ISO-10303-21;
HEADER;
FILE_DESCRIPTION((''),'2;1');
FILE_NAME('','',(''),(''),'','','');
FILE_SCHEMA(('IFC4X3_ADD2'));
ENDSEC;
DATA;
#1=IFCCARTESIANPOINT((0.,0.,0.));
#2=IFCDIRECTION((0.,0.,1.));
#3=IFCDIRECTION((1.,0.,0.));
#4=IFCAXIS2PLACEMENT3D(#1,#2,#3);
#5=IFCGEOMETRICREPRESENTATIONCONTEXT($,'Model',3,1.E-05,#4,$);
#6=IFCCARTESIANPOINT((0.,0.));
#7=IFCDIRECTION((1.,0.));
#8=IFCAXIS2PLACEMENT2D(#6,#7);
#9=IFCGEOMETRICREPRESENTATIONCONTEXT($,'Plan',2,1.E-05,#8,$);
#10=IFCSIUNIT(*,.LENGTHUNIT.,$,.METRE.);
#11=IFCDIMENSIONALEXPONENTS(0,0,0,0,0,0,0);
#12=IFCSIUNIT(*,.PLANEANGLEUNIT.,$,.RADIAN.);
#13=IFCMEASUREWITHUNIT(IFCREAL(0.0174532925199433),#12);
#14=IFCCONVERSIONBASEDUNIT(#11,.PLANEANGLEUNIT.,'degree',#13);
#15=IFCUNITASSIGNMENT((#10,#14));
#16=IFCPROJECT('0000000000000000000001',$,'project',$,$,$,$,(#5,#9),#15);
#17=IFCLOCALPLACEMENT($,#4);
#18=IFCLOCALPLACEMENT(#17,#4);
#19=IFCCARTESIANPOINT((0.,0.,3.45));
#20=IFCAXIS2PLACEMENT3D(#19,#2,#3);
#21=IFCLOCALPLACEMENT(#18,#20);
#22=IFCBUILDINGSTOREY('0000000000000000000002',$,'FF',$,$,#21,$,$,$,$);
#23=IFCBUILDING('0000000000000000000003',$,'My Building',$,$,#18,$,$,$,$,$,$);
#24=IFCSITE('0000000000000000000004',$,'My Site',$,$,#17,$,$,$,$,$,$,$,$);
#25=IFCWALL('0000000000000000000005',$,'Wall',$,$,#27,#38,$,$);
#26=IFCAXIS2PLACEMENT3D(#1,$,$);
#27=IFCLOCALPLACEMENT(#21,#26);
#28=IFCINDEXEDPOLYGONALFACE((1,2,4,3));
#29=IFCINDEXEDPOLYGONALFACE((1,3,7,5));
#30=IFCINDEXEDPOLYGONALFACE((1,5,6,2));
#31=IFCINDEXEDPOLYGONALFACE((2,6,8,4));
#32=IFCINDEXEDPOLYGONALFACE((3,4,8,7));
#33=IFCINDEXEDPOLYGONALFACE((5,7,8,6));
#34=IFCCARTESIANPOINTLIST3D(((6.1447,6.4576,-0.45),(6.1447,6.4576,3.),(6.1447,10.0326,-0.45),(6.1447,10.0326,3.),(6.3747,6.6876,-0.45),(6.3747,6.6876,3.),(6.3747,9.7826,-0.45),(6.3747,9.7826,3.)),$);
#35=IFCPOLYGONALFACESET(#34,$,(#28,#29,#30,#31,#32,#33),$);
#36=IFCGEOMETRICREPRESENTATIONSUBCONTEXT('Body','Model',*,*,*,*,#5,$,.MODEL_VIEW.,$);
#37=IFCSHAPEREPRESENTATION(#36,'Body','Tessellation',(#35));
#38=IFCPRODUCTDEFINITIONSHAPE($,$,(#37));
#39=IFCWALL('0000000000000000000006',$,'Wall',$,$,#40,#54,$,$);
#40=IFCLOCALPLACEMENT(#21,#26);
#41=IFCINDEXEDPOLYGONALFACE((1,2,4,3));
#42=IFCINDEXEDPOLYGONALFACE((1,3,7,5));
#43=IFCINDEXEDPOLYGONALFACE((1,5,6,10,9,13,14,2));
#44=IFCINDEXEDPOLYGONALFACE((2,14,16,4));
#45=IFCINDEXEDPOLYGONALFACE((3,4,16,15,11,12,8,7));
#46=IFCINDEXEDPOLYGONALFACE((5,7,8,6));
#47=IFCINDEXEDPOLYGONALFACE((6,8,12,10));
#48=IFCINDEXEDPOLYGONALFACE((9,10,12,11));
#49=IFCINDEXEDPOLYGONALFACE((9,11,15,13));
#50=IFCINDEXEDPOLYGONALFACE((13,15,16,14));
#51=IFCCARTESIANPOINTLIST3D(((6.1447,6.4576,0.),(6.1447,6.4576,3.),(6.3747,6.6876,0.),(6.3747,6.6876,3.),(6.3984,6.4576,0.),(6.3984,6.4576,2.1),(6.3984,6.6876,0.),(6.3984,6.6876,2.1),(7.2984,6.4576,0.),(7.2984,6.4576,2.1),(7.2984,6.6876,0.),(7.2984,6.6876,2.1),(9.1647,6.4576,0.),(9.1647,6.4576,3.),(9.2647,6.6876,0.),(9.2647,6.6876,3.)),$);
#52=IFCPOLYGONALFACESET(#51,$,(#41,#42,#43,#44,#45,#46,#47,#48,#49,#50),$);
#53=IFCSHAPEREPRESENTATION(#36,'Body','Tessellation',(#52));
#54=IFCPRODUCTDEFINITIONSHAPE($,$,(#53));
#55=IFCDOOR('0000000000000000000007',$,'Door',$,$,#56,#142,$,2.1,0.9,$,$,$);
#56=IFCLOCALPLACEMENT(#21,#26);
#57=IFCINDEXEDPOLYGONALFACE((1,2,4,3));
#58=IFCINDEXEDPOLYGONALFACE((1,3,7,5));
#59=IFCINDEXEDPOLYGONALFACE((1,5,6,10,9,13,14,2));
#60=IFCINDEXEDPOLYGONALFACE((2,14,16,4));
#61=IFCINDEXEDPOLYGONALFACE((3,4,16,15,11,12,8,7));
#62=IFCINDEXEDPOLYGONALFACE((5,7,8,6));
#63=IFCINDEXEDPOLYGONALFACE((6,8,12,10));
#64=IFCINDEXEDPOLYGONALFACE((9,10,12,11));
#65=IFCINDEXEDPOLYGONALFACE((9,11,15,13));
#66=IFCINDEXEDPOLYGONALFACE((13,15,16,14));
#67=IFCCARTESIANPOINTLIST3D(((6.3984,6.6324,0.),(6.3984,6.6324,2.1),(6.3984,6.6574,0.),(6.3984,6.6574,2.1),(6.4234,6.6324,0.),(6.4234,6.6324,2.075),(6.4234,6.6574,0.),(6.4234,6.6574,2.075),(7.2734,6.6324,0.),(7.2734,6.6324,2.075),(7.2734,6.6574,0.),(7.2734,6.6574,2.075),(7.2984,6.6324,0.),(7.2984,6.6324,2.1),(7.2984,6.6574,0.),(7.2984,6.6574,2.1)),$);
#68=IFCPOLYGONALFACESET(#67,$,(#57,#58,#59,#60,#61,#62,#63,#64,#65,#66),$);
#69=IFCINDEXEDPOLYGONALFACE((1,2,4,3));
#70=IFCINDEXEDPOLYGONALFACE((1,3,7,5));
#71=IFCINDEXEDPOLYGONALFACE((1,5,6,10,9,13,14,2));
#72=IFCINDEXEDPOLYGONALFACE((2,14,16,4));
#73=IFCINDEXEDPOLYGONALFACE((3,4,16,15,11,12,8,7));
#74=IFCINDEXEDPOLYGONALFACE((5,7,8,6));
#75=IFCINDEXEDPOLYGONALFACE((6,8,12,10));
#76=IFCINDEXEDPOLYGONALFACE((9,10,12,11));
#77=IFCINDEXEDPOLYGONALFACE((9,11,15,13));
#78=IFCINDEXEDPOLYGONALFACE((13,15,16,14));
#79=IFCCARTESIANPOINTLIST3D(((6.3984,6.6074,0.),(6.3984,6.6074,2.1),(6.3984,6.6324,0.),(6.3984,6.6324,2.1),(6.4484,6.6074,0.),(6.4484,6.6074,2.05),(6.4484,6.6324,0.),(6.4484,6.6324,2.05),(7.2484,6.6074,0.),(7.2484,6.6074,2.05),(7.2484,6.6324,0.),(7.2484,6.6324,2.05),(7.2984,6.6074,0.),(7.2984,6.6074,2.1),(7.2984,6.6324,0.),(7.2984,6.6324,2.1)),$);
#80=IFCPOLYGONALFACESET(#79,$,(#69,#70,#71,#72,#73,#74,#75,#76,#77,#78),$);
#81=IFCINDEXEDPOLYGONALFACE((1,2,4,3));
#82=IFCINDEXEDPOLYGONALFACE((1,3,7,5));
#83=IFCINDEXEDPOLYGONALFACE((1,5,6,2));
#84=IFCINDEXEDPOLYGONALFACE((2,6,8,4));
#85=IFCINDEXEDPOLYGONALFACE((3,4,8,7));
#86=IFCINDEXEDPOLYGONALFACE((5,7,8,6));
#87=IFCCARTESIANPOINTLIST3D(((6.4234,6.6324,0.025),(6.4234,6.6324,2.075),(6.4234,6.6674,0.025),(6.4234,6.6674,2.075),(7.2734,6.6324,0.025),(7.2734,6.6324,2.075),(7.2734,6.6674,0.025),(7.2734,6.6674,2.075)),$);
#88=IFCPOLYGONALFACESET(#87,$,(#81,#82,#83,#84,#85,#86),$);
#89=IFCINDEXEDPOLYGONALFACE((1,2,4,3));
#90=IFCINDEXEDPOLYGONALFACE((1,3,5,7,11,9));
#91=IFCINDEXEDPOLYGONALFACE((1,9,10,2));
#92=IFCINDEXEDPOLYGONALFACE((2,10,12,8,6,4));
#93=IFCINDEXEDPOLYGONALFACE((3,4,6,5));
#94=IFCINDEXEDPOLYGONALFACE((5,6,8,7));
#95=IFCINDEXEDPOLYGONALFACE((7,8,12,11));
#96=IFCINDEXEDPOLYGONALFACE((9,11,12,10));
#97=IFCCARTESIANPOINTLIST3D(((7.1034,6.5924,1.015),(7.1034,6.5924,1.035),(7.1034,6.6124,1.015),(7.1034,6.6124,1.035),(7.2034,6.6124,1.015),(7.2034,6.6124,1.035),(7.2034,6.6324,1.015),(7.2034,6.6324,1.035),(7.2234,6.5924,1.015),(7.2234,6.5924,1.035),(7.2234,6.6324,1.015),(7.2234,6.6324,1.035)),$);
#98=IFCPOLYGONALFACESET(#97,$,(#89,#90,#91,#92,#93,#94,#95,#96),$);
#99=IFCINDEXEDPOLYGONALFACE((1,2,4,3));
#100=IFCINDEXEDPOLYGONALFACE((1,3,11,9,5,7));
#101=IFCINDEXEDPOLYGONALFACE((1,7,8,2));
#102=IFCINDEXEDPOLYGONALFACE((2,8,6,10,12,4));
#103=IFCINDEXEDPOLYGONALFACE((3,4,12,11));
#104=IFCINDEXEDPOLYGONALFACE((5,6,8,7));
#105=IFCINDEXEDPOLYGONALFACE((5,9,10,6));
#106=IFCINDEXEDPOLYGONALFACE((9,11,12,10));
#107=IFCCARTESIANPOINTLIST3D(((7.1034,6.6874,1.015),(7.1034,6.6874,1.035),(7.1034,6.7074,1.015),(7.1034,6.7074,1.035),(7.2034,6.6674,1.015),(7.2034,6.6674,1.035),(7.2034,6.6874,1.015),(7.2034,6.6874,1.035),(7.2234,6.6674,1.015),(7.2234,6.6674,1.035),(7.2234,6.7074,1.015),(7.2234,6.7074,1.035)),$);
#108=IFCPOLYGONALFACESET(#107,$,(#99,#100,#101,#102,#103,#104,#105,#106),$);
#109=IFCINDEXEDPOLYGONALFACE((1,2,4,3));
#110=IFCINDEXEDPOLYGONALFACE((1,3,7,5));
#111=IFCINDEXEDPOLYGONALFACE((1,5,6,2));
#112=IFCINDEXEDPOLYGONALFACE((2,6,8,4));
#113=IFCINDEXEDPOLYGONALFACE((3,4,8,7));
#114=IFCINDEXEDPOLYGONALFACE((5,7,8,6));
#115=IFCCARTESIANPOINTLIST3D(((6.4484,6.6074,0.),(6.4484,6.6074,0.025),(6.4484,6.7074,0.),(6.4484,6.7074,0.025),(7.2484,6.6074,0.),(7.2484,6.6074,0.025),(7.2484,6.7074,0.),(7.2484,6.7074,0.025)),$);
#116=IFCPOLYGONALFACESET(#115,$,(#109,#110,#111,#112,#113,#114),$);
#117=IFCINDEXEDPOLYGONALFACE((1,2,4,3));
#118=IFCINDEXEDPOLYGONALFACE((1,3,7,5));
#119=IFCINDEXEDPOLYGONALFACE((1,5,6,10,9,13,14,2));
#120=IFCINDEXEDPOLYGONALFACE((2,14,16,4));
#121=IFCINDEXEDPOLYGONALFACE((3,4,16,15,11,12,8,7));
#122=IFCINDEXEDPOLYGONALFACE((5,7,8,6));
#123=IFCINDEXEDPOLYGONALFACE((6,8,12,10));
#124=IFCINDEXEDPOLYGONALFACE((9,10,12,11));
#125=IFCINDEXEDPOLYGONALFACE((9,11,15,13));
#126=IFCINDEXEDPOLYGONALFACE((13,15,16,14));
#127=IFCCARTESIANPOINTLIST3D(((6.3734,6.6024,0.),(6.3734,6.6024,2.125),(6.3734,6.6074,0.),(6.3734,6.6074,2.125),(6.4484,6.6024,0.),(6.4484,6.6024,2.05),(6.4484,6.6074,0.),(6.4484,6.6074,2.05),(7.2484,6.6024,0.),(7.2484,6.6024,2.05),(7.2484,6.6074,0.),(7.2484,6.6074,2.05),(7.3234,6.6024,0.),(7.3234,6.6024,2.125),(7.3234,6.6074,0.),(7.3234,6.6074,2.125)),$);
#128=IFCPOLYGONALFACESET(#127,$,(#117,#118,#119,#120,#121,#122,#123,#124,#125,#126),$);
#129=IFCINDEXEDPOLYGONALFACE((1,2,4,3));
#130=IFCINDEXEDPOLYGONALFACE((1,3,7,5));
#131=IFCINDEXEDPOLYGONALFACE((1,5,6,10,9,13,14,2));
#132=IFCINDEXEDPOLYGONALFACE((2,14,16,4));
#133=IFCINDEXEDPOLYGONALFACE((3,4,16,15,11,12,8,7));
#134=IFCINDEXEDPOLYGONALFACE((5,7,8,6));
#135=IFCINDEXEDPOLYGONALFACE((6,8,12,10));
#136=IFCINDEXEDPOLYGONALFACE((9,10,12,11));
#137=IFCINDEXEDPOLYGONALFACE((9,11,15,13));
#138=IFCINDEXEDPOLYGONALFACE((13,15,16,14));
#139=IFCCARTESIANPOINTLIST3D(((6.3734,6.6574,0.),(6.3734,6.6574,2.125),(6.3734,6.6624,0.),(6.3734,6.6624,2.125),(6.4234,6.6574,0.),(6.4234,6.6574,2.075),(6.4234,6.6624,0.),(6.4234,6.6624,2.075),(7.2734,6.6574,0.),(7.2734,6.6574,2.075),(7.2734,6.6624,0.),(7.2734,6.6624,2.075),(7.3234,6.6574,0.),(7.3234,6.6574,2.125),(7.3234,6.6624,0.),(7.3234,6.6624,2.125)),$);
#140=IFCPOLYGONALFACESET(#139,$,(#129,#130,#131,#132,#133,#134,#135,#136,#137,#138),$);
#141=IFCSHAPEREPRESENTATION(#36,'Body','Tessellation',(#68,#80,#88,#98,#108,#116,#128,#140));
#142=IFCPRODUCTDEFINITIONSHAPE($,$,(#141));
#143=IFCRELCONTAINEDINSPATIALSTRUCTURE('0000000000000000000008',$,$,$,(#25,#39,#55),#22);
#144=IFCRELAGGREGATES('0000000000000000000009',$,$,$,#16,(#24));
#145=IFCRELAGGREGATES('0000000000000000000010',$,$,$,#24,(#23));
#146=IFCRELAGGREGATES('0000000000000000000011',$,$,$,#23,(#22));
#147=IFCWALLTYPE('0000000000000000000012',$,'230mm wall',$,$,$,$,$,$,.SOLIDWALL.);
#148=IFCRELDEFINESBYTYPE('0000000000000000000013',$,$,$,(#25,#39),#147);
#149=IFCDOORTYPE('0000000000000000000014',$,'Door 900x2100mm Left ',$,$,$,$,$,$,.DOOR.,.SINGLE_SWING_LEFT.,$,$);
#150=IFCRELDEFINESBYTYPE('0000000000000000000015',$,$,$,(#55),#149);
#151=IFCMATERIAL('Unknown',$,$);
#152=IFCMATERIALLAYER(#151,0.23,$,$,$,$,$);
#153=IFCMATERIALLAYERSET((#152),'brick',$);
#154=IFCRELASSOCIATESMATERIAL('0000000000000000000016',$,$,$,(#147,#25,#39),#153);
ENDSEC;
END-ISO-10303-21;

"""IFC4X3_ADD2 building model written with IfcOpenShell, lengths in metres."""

from ifc_helpers import new_model, entity, si_unit, converted_unit, frame, origin_with_axes, origin_2d_with_axis, place, context, subcontext, project, spatial, line, indexed_curve, outline, extrude, shape, source, transform, mapped, material, layer, layer_set, layer_usage, type_object, type_shapes, element, fill, save


model = new_model("IFC4X3_ADD2")

# Units and contexts
model_context = context("Model", 3, precision=1e-05, world=origin_with_axes())
plan_context = context("Plan", 2, precision=1e-05, world=origin_2d_with_axis())
body_context_1 = subcontext(model_context, "Body", "Model", "MODEL_VIEW")
body_context_2 = subcontext(plan_context, "Body", "Plan", "PLAN_VIEW")
ifc_project = project(units=[si_unit("LENGTHUNIT", "METRE"), converted_unit("PLANEANGLEUNIT", "degree", entity("IfcReal", 0.0174532925199433), si_unit("PLANEANGLEUNIT", "RADIAN"), dimensions=[0, 0, 0, 0, 0, 0, 0])], contexts=[model_context, plan_context])

# Site, building, storey
site_placement = place(None, origin_with_axes())
site = spatial("IfcSite", under=ifc_project, at=site_placement, Name="My Site")
building_placement = place(site_placement, origin_with_axes())
building = spatial("IfcBuilding", under=site, at=building_placement, Name="My Building")
storey_placement = place(building_placement, frame((0.0, 0.0, 3.45), z_axis=(0.0, 0.0, 1.0), x_axis=(1.0, 0.0, 0.0)))
storey = spatial("IfcBuildingStorey", under=building, at=storey_placement, Name="FF")

# Shared definitions
ifc_material = material(Name="Unknown")

# Shared definitions
ifc_layer_1 = layer(ifc_material, 0.23)
ifc_layer_set_1 = layer_set([ifc_layer_1], Name="brick")
wall_type_1 = type_object("IfcWallType", Name="230mm wall", PredefinedType="SOLIDWALL", material=ifc_layer_set_1)

# Wall
ifc_layer_usage_1 = layer_usage(ifc_layer_set_1, "AXIS2", "POSITIVE", 0.0)
wall_1_placement = place(storey_placement, frame((6.3747, 6.6876, -0.45), z_axis=(0.0, 0.0, 1.0), x_axis=(0.0, 1.0, 0.0)))
element("IfcWall", 1, at=wall_1_placement, inside=storey, type_object=wall_type_1, material=ifc_layer_usage_1, Name="Wall", context=body_context_1, shape_type="SweptSolid", body=[
    extrude(outline(indexed_curve([(0.0, 0.0), (-0.23, 0.23), (3.345, 0.23), (3.095, 0.0)], segments=[line(1, 2, 3, 4, 1)])), origin_with_axes(), (0.0, 0.0, 1.0), 3.45),
])

# Wall, opening, door
ifc_layer_usage_2 = layer_usage(ifc_layer_set_1, "AXIS2", "POSITIVE", 0.0)
wall_2_placement = place(storey_placement, frame((9.2647, 6.6876, 0.0), z_axis=(0.0, 0.0, 1.0), x_axis=(-1.0, 0.0, 0.0)))
wall_2 = element("IfcWall", 2, at=wall_2_placement, inside=storey, type_object=wall_type_1, material=ifc_layer_usage_2, Name="Wall", context=body_context_1, shape_type="SweptSolid", body=[
    extrude(outline(indexed_curve([(0.0, 0.0), (0.1, 0.23), (3.12, 0.23), (2.89, 0.0)], segments=[line(1, 2, 3, 4, 1)])), origin_with_axes(), (0.0, 0.0, 1.0), 3.0),
])
shared_shape_1 = source(origin_with_axes(), body_context_1, "Body", "SweptSolid", [
    extrude(outline(indexed_curve([(0.0, 0.0), (0.9, 0.0), (0.9, 2.1), (0.0, 2.1)], segments=[line(1, 2, 3, 4, 1)])), frame((0.0, -0.6, 0.0), z_axis=(0.0, -1.0, 0.0), x_axis=(1.0, 0.0, 0.0)), (0.0, 0.0, -1.0), 1.2),
])
opening_1_placement = place(wall_2_placement, frame((2.8663, 0.0801, 0.0), z_axis=(0.0, 0.0, 1.0), x_axis=(-1.0, 0.0, 0.0)))
opening_1 = element("IfcOpeningElement", 3, at=opening_1_placement, cuts=wall_2, PredefinedType="OPENING", context=body_context_1, shape_type="MappedRepresentation", body=[
    mapped(shared_shape_1, transform((0.0, 0.0, 0.0), x_axis=(1.0, 0.0, 0.0), y_axis=(0.0, 1.0, 0.0), z_axis=(0.0, 0.0, 1.0), scale=1.0)),
])
door_type_1 = type_object("IfcDoorType", Name="Door 900x2100mm Left ", OperationType="SINGLE_SWING_LEFT", PredefinedType="DOOR")
shared_shape_2 = source(origin_with_axes(), body_context_1, "Body", "SweptSolid", [
    extrude(outline(indexed_curve([(0.0, 0.0), (0.0, 2.1), (0.9, 2.1), (0.9, 0.0), (0.875, 0.0), (0.875, 2.075), (0.025, 2.075), (0.025, 0.0)], segments=[line(1, 2, 3, 4, 5, 6, 7, 8, 1)])), frame((0.0, 0.025, 0.0), z_axis=(0.0, -1.0, 0.0), x_axis=(1.0, 0.0, 0.0)), (0.0, 0.0, -1.0), 0.025),
    extrude(outline(indexed_curve([(0.0, 0.0), (0.0, 2.1), (0.9, 2.1), (0.9, 0.0), (0.85, 0.0), (0.85, 2.05), (0.05, 2.05), (0.05, 0.0)], segments=[line(1, 2, 3, 4, 5, 6, 7, 8, 1)])), frame((0.0, 0.0, 0.0), z_axis=(0.0, -1.0, 0.0), x_axis=(1.0, 0.0, 0.0)), (0.0, 0.0, -1.0), 0.025),
    extrude(outline(indexed_curve([(0.0, 0.0), (0.85, 0.0), (0.85, 0.035), (0.0, 0.035)], segments=[line(1, 2, 3, 4, 1)])), frame((0.025, 0.025, 0.025), z_axis=(0.0, 0.0, 1.0), x_axis=(1.0, 0.0, 0.0)), (0.0, 0.0, 1.0), 2.05),
    extrude(outline(indexed_curve([(0.0, 0.0), (0.0, -0.04), (-0.12, -0.04), (-0.12, -0.02), (-0.02, -0.02), (-0.02, 0.0)], segments=[line(1, 2, 3, 4, 5, 6, 1)])), frame((0.825, 0.025, 1.015), z_axis=(0.0, 0.0, 1.0), x_axis=(1.0, 0.0, 0.0)), (0.0, 0.0, 1.0), 0.02),
    extrude(outline(indexed_curve([(0.0, 0.0), (0.0, 0.04), (-0.12, 0.04), (-0.12, 0.02), (-0.02, 0.02), (-0.02, 0.0)], segments=[line(1, 2, 3, 4, 5, 6, 1)])), frame((0.825, 0.06, 1.015), z_axis=(0.0, 0.0, 1.0), x_axis=(1.0, 0.0, 0.0)), (0.0, 0.0, 1.0), 0.02),
    extrude(outline(indexed_curve([(0.0, 0.0), (0.8, 0.0), (0.8, 0.1), (0.0, 0.1)], segments=[line(1, 2, 3, 4, 1)])), frame((0.05, 0.0, 0.0), z_axis=(0.0, 0.0, 1.0), x_axis=(1.0, 0.0, 0.0)), (0.0, 0.0, 1.0), 0.025),
    extrude(outline(indexed_curve([(0.0, 0.0), (0.0, 2.125), (0.95, 2.125), (0.95, 0.0), (0.875, 0.0), (0.875, 2.05), (0.075, 2.05), (0.075, 0.0)], segments=[line(1, 2, 3, 4, 5, 6, 7, 8, 1)])), frame((-0.025, -0.005, 0.0), z_axis=(0.0, -1.0, 0.0), x_axis=(1.0, 0.0, 0.0)), (0.0, 0.0, -1.0), 0.005),
    extrude(outline(indexed_curve([(0.0, 0.0), (0.0, 2.125), (0.95, 2.125), (0.95, 0.0), (0.9, 0.0), (0.9, 2.075), (0.05, 2.075), (0.05, 0.0)], segments=[line(1, 2, 3, 4, 5, 6, 7, 8, 1)])), frame((-0.025, 0.05, 0.0), z_axis=(0.0, -1.0, 0.0), x_axis=(1.0, 0.0, 0.0)), (0.0, 0.0, -1.0), 0.005),
])
shared_shape_3 = source(origin_with_axes(), body_context_2, "Body", "Curve2D", [
    entity("IfcIndexedPolyCurve", entity("IfcCartesianPointList2D", [[0.0, 0.0], [0.0, 0.05], [0.025, 0.05], [0.025, 0.025], [0.05, 0.025], [0.05, 0.0]]), [entity("IfcLineIndex", [1, 2, 3, 4, 5, 6, 1])]),
    entity("IfcIndexedPolyCurve", entity("IfcCartesianPointList2D", [[0.9, 0.0], [0.9, 0.05], [0.875, 0.05], [0.875, 0.025], [0.85, 0.025], [0.85, 0.0]]), [entity("IfcLineIndex", [1, 2, 3, 4, 5, 6, 1])]),
    entity("IfcTrimmedCurve", entity("IfcEllipse", entity("IfcAxis2Placement2D", entity("IfcCartesianPoint", [0.06, 0.05]), entity("IfcDirection", [1.0, 0.0])), 0.815, 0.85), [entity("IfcCartesianPoint", [0.875, 0.05])], [entity("IfcCartesianPoint", [0.06, 0.9])], True, "CARTESIAN"),
    entity("IfcIndexedPolyCurve", entity("IfcCartesianPointList2D", [[0.025, 0.05], [0.06, 0.05], [0.06, 0.9], [0.025, 0.9]]), [entity("IfcLineIndex", [1, 2, 3, 4, 1])]),
])
type_shapes(door_type_1, [shared_shape_2, shared_shape_3])
door_1_placement = place(opening_1_placement, frame((0.0, 0.0, 0.0), z_axis=(0.0, 0.0, 1.0), x_axis=(1.0, 0.0, 0.0)))
door_1 = element("IfcDoor", 4, at=door_1_placement, inside=storey, type_object=door_type_1, Name="Door", OverallHeight=2.1, OverallWidth=0.9, shapes=[
    shape(body_context_1, "Body", "MappedRepresentation", [mapped(shared_shape_2, transform((0.0, 0.0, 0.0), x_axis=(1.0, 0.0, 0.0), y_axis=(0.0, 1.0, 0.0), z_axis=(0.0, 0.0, 1.0), scale=1.0))]),
    shape(body_context_2, "Body", "MappedRepresentation", [mapped(shared_shape_3, transform((0.0, 0.0, 0.0), x_axis=(1.0, 0.0, 0.0), y_axis=(0.0, 1.0, 0.0), z_axis=(0.0, 0.0, 1.0), scale=1.0))]),
])
fill(opening_1, door_1)

save(model, "model.ifc")
